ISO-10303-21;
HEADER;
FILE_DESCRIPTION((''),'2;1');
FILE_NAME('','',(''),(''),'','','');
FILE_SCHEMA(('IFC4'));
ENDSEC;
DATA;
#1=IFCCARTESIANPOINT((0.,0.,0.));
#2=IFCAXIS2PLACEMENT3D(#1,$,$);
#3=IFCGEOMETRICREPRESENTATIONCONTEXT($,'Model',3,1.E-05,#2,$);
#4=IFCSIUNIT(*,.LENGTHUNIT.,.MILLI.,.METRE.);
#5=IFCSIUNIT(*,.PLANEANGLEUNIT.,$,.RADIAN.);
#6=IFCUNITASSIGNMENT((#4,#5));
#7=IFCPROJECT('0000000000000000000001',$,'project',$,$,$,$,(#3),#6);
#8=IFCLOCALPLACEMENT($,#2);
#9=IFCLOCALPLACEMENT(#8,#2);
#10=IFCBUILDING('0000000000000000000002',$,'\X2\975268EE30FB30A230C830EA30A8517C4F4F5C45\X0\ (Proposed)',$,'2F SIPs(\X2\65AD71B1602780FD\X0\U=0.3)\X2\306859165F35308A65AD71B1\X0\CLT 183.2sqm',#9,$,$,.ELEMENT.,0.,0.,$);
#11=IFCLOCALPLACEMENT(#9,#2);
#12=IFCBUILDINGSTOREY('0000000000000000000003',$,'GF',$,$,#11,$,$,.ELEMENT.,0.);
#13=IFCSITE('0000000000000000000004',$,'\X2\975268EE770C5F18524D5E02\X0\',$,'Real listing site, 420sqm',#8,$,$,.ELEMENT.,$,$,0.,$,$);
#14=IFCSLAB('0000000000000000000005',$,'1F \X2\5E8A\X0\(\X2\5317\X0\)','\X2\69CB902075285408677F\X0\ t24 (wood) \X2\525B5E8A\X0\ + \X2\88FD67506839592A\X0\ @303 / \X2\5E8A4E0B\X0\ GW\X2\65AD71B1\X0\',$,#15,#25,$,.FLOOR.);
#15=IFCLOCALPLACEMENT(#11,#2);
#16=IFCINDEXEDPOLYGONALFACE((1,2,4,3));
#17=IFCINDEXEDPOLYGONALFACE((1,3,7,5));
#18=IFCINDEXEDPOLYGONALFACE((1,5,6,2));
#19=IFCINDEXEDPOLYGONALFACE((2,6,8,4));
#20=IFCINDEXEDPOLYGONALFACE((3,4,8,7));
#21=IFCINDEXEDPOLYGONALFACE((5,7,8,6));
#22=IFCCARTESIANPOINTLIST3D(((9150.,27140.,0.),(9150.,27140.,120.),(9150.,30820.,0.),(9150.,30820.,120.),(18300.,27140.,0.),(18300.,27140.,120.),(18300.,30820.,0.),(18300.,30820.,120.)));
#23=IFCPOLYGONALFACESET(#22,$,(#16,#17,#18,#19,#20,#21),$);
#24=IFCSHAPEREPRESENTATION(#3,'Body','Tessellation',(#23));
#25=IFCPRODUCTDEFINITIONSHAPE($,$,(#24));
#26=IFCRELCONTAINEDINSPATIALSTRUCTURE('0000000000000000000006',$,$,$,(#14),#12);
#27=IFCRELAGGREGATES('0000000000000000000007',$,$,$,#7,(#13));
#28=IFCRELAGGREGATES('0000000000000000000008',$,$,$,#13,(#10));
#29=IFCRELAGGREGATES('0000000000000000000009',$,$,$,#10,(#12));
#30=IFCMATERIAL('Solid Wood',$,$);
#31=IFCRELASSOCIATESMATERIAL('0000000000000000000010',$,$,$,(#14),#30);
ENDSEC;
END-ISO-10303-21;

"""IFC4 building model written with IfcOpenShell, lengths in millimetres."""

from ifc_helpers import new_model, si_unit, frame, frame_2d, origin, place, context, project, spatial, rectangle, extrude, material, element, save


model = new_model("IFC4")

# Units and contexts
model_context = context("Model", 3, precision=1e-05, world=origin())
ifc_project = project(units=[si_unit("LENGTHUNIT", "METRE", prefix="MILLI"), si_unit("PLANEANGLEUNIT", "RADIAN")], contexts=[model_context])

# Site, building, storey
site_placement = place(None, origin())
site = spatial("IfcSite", under=ifc_project, at=site_placement, Name="青森県弘前市", ObjectType="Real listing site, 420sqm", CompositionType="ELEMENT", RefElevation=0.0)
building_placement = place(site_placement, origin())
building = spatial("IfcBuilding", under=site, at=building_placement, Name="青森・アトリエ兼住居 (Proposed)", ObjectType="2F SIPs(断熱性能U=0.3)と外張り断熱CLT 183.2sqm", CompositionType="ELEMENT", ElevationOfRefHeight=0.0, ElevationOfTerrain=0.0)
storey_placement = place(building_placement, origin())
storey = spatial("IfcBuildingStorey", under=building, at=storey_placement, Name="GF", CompositionType="ELEMENT", Elevation=0.0)

# Shared definitions
ifc_material_1 = material(Name="Solid Wood")

# Slab
slab_1_placement = place(storey_placement, frame((4575.0, 13570.0, 0.0)))
element("IfcSlab", 1, at=slab_1_placement, inside=storey, material=ifc_material_1, Name="1F 床(北)", Description="構造用合板 t24 (wood) 剛床 + 製材根太 @303 / 床下 GW断熱", PredefinedType="FLOOR", context=model_context, shape_type="SweptSolid", body=[
    extrude(rectangle(XDim=9150.0, YDim=3680.0, at=frame_2d((4575.0, 1840.0))), frame((4575.0, 13570.0, 0.0)), (0.0, 0.0, 1.0), 120.0),
])

save(model, "model.ifc")
